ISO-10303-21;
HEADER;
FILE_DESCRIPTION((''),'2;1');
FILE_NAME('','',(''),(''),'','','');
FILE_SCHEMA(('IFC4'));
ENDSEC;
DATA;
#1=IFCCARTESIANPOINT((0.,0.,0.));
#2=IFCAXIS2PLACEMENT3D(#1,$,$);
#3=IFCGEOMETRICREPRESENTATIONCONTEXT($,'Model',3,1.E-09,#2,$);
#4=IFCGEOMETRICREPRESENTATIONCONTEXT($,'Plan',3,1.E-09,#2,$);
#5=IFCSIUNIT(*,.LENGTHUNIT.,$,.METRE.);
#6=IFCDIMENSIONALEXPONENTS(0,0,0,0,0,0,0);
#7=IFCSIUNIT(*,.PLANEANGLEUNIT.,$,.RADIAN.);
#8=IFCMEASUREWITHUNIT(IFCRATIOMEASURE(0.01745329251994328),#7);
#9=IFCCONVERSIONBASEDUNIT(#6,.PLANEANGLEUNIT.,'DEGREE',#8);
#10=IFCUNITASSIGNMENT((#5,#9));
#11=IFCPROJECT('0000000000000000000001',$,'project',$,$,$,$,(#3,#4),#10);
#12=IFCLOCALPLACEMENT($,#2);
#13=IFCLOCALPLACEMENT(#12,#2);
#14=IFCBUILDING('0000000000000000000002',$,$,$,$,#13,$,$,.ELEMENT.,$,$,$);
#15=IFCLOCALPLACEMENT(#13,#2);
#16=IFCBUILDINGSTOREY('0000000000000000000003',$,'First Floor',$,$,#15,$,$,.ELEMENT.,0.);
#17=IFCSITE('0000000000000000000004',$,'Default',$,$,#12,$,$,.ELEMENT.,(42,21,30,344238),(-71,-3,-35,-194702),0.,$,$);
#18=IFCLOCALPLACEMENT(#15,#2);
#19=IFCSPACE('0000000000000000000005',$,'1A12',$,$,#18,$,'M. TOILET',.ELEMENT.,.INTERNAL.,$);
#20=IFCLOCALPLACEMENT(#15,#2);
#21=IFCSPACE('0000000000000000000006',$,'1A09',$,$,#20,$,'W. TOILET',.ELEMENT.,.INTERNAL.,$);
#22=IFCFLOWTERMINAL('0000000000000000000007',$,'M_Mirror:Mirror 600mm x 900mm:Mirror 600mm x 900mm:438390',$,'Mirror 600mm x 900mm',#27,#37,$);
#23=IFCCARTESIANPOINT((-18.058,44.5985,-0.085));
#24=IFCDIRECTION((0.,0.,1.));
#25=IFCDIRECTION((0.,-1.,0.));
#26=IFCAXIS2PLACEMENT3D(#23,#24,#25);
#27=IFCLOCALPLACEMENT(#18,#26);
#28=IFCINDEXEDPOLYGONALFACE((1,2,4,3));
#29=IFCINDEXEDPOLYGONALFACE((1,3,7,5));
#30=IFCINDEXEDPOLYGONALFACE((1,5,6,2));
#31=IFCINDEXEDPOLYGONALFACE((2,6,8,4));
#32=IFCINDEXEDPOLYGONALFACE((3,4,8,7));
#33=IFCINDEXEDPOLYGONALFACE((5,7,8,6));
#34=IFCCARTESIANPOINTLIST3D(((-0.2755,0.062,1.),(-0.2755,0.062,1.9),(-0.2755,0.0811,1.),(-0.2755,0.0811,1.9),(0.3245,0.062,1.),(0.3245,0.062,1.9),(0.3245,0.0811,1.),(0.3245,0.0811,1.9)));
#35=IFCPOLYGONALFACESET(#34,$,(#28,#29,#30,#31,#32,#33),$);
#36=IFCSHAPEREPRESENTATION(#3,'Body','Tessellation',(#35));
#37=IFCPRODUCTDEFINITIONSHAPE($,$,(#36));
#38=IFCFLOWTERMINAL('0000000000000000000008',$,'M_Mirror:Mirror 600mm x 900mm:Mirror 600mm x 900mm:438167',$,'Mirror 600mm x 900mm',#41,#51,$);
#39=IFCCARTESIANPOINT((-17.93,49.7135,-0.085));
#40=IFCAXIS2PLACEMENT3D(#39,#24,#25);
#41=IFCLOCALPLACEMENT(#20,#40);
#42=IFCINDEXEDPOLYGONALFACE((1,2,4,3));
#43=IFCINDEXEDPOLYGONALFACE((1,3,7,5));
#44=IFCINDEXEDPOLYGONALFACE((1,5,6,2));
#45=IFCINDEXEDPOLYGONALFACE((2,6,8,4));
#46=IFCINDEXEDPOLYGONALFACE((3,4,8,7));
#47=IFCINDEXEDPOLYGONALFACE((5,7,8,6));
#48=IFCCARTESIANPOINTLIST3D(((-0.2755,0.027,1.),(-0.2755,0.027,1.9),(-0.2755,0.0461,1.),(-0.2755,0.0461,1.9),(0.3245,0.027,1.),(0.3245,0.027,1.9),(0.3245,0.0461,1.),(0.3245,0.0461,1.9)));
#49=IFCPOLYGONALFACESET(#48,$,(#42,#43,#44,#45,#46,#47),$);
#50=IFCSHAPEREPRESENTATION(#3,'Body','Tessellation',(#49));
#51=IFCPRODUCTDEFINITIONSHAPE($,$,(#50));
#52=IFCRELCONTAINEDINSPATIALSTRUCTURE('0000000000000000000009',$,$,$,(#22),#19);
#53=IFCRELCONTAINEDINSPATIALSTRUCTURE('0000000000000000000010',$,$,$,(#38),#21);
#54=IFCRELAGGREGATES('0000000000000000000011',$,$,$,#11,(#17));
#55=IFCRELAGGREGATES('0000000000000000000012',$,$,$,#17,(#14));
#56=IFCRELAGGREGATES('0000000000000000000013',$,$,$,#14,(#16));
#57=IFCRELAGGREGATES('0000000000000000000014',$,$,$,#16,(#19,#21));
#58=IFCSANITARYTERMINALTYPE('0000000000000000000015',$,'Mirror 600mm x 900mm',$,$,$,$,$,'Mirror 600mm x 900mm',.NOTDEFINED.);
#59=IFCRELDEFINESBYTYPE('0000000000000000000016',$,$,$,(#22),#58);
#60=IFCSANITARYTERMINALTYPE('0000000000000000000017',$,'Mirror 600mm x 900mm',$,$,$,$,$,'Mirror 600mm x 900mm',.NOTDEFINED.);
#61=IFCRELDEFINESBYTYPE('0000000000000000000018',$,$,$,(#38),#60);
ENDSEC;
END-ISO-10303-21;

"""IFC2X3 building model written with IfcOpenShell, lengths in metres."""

from ifc_helpers import new_model, entity, si_unit, converted_unit, frame, origin, origin_2d_with_axis, place, context, project, spatial, rectangle, extrude, source, transform, mapped, type_object, type_shapes, element, save


model = new_model("IFC2X3")

# Units and contexts
model_context = context("Model", 3, precision=1e-09, world=origin())
plan_context = context("Plan", 3, precision=1e-09, world=origin())
ifc_project = project(units=[si_unit("LENGTHUNIT", "METRE"), converted_unit("PLANEANGLEUNIT", "DEGREE", entity("IfcRatioMeasure", 0.01745329251994328), si_unit("PLANEANGLEUNIT", "RADIAN"), dimensions=[0, 0, 0, 0, 0, 0, 0])], contexts=[model_context, plan_context])

# Site, building, storey
site_placement = place(None, origin())
site = spatial("IfcSite", under=ifc_project, at=site_placement, Name="Default", CompositionType="ELEMENT", RefLatitude=(42, 21, 30, 344238), RefLongitude=(-71, -3, -35, -194702), RefElevation=0.0)
building_placement = place(site_placement, origin())
building = spatial("IfcBuilding", under=site, at=building_placement, CompositionType="ELEMENT")
storey_placement = place(building_placement, origin())
storey = spatial("IfcBuildingStorey", under=building, at=storey_placement, Name="First Floor", CompositionType="ELEMENT", Elevation=0.0)

# Shared definitions
space_1_placement = place(storey_placement, origin())
space_1 = spatial("IfcSpace", under=storey, at=space_1_placement, Name="1A12", LongName="M. TOILET", CompositionType="ELEMENT", InteriorOrExteriorSpace="INTERNAL")

# Flow terminal
sanitary_terminal_type_1 = type_object("IfcSanitaryTerminalType", Name="Mirror 600mm x 900mm", ElementType="Mirror 600mm x 900mm", PredefinedType="NOTDEFINED")
shared_shape_1 = source(origin(), model_context, "Body", "SweptSolid", [
    extrude(rectangle(XDim=0.0191, YDim=0.6, at=origin_2d_with_axis()), frame((0.0245, 0.0715, 1.0), z_axis=(0.0, 0.0, 1.0), x_axis=(0.0, -1.0, 0.0)), (0.0, 0.0, 1.0), 0.9),
])
type_shapes(sanitary_terminal_type_1, [shared_shape_1])
flow_terminal_1_placement = place(space_1_placement, frame((-18.058, 44.5985, -0.085), z_axis=(0.0, 0.0, 1.0), x_axis=(0.0, -1.0, 0.0)))
element("IfcFlowTerminal", 1, at=flow_terminal_1_placement, inside=space_1, type_object=sanitary_terminal_type_1, Name="M_Mirror:Mirror 600mm x 900mm:Mirror 600mm x 900mm:438390", ObjectType="Mirror 600mm x 900mm", context=model_context, shape_type="MappedRepresentation", body=[
    mapped(shared_shape_1, transform((0.0, 0.0, 0.0), scale=1.0)),
])

# Shared definitions
space_2_placement = place(storey_placement, origin())
space_2 = spatial("IfcSpace", under=storey, at=space_2_placement, Name="1A09", LongName="W. TOILET", CompositionType="ELEMENT", InteriorOrExteriorSpace="INTERNAL")

# Flow terminal
sanitary_terminal_type_2 = type_object("IfcSanitaryTerminalType", Name="Mirror 600mm x 900mm", ElementType="Mirror 600mm x 900mm", PredefinedType="NOTDEFINED")
shared_shape_2 = source(origin(), model_context, "Body", "SweptSolid", [
    extrude(rectangle(XDim=0.019, YDim=0.6, at=origin_2d_with_axis()), frame((0.0245, 0.0365, 1.0), z_axis=(0.0, 0.0, 1.0), x_axis=(0.0, -1.0, 0.0)), (0.0, 0.0, 1.0), 0.9),
])
type_shapes(sanitary_terminal_type_2, [shared_shape_2])
flow_terminal_2_placement = place(space_2_placement, frame((-17.93, 49.7135, -0.085), z_axis=(0.0, 0.0, 1.0), x_axis=(0.0, -1.0, 0.0)))
element("IfcFlowTerminal", 2, at=flow_terminal_2_placement, inside=space_2, type_object=sanitary_terminal_type_2, Name="M_Mirror:Mirror 600mm x 900mm:Mirror 600mm x 900mm:438167", ObjectType="Mirror 600mm x 900mm", context=model_context, shape_type="MappedRepresentation", body=[
    mapped(shared_shape_2, transform((0.0, 0.0, 0.0), scale=1.0)),
])

save(model, "model.ifc")
